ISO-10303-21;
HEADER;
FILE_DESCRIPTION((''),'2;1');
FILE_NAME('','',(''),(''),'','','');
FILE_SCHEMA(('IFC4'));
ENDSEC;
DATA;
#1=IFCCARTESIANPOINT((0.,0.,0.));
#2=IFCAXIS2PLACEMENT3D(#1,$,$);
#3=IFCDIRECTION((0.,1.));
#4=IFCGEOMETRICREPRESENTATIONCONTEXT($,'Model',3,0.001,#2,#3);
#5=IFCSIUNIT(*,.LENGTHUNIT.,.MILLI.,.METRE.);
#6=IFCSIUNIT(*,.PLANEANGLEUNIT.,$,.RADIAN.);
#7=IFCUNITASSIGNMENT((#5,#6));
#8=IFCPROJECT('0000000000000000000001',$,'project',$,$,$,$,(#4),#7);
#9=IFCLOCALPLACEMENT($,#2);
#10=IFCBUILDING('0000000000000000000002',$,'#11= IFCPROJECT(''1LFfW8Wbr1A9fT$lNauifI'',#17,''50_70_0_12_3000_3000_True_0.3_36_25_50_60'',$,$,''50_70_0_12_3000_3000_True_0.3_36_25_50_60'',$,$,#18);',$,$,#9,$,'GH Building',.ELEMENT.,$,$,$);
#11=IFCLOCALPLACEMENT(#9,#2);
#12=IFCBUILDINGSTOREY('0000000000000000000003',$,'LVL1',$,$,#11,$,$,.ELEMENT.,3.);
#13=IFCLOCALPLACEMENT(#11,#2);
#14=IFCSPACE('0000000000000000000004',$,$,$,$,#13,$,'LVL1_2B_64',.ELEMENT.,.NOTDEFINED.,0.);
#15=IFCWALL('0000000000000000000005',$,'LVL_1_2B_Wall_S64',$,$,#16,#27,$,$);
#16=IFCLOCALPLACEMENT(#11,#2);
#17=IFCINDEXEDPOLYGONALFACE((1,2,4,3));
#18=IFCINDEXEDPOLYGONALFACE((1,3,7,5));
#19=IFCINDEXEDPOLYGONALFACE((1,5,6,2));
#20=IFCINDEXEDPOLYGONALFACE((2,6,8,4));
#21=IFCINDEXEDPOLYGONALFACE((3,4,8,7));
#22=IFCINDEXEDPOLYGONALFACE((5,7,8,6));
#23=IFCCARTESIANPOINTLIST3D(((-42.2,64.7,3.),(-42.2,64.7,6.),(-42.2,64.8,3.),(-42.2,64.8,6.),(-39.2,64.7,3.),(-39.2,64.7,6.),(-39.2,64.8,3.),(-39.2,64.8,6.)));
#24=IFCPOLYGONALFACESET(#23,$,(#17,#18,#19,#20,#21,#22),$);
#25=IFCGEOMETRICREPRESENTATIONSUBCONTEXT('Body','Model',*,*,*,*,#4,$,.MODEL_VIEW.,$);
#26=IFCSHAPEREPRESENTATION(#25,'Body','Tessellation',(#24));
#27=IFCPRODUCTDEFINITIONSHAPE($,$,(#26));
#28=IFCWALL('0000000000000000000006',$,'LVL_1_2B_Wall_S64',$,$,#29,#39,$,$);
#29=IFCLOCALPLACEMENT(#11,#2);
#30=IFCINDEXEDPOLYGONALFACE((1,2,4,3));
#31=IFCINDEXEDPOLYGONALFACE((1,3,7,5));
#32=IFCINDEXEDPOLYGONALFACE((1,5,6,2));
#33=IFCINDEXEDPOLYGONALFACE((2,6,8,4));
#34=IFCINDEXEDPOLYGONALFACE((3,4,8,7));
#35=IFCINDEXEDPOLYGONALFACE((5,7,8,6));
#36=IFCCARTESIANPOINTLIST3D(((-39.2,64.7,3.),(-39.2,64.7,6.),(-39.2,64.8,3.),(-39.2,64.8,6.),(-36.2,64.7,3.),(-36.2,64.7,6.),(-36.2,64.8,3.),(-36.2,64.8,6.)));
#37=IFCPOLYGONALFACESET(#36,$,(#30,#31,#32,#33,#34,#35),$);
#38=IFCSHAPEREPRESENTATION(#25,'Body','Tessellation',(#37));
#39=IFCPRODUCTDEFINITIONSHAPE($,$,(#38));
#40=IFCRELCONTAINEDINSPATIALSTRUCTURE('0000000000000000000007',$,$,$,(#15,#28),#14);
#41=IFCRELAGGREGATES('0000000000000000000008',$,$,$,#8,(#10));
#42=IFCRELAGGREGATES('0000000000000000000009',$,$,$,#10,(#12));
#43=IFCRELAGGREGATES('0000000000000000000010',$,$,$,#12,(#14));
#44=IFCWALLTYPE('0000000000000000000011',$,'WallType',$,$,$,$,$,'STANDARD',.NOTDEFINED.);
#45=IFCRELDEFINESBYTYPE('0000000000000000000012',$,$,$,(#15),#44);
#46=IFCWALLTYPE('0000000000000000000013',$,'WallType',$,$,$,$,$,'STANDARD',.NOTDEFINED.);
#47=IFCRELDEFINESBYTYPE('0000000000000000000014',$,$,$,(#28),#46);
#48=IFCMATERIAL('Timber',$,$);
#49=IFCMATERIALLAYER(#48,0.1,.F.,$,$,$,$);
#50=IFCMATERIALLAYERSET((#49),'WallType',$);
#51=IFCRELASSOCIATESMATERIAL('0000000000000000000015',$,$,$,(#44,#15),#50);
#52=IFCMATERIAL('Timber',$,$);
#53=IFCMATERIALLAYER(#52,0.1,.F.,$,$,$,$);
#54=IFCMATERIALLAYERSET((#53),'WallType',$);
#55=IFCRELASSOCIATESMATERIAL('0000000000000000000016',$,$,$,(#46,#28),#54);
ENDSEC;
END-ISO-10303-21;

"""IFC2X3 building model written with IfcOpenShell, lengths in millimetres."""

from ifc_helpers import new_model, si_unit, direction, frame, frame_2d, origin, place, context, subcontext, project, spatial, rectangle, extrude, material, layer, layer_set, layer_usage, type_object, element, save


model = new_model("IFC2X3")

# Units and contexts
model_context = context("Model", 3, precision=0.001, world=origin(), true_north=direction((0.0, 1.0)))
body_context = subcontext(model_context, "Body", "Model", "MODEL_VIEW")
ifc_project = project(units=[si_unit("LENGTHUNIT", "METRE", prefix="MILLI"), si_unit("PLANEANGLEUNIT", "RADIAN")], contexts=[model_context])

# Building, storey
building_placement = place(None, origin())
building = spatial("IfcBuilding", under=ifc_project, at=building_placement, Name="#11= IFCPROJECT('1LFfW8Wbr1A9fT$lNauifI',#17,'50_70_0_12_3000_3000_True_0.3_36_25_50_60',$,$,'50_70_0_12_3000_3000_True_0.3_36_25_50_60',$,$,#18);", LongName="GH Building", CompositionType="ELEMENT")
storey_placement = place(building_placement, origin())
storey = spatial("IfcBuildingStorey", under=building, at=storey_placement, Name="LVL1", CompositionType="ELEMENT", Elevation=3.0)

# Shared definitions
space_1_placement = place(storey_placement, origin())
space_1 = spatial("IfcSpace", under=storey, at=space_1_placement, LongName="LVL1_2B_64", CompositionType="ELEMENT", InteriorOrExteriorSpace="NOTDEFINED", ElevationWithFlooring=0.0)

# Walls
ifc_material_1 = material(Name="Timber")
ifc_layer_1 = layer(ifc_material_1, 0.1, ventilated=False)
ifc_layer_set_1 = layer_set([ifc_layer_1], Name="WallType")
ifc_layer_usage_1 = layer_usage(ifc_layer_set_1, "AXIS2", "NEGATIVE", 0.0)
wall_type_1 = type_object("IfcWallType", Name="WallType", ElementType="STANDARD", PredefinedType="NOTDEFINED", material=ifc_layer_set_1)
wall_1_placement = place(space_1_placement, frame((-42.2, 64.8, 3.0)))
element("IfcWall", 1, at=wall_1_placement, inside=space_1, type_object=wall_type_1, material=ifc_layer_usage_1, Name="LVL_1_2B_Wall_S64", context=body_context, shape_type="SweptSolid", body=[
    extrude(rectangle(XDim=3.0, YDim=0.1, at=frame_2d((1.5, -0.1))), origin(), (0.0, 0.0, 1.0), 3.0),
])
ifc_material_2 = material(Name="Timber")
ifc_layer_2 = layer(ifc_material_2, 0.1, ventilated=False)
ifc_layer_set_2 = layer_set([ifc_layer_2], Name="WallType")
ifc_layer_usage_2 = layer_usage(ifc_layer_set_2, "AXIS2", "NEGATIVE", 0.0)
wall_type_2 = type_object("IfcWallType", Name="WallType", ElementType="STANDARD", PredefinedType="NOTDEFINED", material=ifc_layer_set_2)
wall_2_placement = place(space_1_placement, frame((-39.2, 64.8, 3.0)))
element("IfcWall", 2, at=wall_2_placement, inside=space_1, type_object=wall_type_2, material=ifc_layer_usage_2, Name="LVL_1_2B_Wall_S64", context=body_context, shape_type="SweptSolid", body=[
    extrude(rectangle(XDim=3.0, YDim=0.1, at=frame_2d((1.5, -0.1))), origin(), (0.0, 0.0, 1.0), 3.0),
])

save(model, "model.ifc")
